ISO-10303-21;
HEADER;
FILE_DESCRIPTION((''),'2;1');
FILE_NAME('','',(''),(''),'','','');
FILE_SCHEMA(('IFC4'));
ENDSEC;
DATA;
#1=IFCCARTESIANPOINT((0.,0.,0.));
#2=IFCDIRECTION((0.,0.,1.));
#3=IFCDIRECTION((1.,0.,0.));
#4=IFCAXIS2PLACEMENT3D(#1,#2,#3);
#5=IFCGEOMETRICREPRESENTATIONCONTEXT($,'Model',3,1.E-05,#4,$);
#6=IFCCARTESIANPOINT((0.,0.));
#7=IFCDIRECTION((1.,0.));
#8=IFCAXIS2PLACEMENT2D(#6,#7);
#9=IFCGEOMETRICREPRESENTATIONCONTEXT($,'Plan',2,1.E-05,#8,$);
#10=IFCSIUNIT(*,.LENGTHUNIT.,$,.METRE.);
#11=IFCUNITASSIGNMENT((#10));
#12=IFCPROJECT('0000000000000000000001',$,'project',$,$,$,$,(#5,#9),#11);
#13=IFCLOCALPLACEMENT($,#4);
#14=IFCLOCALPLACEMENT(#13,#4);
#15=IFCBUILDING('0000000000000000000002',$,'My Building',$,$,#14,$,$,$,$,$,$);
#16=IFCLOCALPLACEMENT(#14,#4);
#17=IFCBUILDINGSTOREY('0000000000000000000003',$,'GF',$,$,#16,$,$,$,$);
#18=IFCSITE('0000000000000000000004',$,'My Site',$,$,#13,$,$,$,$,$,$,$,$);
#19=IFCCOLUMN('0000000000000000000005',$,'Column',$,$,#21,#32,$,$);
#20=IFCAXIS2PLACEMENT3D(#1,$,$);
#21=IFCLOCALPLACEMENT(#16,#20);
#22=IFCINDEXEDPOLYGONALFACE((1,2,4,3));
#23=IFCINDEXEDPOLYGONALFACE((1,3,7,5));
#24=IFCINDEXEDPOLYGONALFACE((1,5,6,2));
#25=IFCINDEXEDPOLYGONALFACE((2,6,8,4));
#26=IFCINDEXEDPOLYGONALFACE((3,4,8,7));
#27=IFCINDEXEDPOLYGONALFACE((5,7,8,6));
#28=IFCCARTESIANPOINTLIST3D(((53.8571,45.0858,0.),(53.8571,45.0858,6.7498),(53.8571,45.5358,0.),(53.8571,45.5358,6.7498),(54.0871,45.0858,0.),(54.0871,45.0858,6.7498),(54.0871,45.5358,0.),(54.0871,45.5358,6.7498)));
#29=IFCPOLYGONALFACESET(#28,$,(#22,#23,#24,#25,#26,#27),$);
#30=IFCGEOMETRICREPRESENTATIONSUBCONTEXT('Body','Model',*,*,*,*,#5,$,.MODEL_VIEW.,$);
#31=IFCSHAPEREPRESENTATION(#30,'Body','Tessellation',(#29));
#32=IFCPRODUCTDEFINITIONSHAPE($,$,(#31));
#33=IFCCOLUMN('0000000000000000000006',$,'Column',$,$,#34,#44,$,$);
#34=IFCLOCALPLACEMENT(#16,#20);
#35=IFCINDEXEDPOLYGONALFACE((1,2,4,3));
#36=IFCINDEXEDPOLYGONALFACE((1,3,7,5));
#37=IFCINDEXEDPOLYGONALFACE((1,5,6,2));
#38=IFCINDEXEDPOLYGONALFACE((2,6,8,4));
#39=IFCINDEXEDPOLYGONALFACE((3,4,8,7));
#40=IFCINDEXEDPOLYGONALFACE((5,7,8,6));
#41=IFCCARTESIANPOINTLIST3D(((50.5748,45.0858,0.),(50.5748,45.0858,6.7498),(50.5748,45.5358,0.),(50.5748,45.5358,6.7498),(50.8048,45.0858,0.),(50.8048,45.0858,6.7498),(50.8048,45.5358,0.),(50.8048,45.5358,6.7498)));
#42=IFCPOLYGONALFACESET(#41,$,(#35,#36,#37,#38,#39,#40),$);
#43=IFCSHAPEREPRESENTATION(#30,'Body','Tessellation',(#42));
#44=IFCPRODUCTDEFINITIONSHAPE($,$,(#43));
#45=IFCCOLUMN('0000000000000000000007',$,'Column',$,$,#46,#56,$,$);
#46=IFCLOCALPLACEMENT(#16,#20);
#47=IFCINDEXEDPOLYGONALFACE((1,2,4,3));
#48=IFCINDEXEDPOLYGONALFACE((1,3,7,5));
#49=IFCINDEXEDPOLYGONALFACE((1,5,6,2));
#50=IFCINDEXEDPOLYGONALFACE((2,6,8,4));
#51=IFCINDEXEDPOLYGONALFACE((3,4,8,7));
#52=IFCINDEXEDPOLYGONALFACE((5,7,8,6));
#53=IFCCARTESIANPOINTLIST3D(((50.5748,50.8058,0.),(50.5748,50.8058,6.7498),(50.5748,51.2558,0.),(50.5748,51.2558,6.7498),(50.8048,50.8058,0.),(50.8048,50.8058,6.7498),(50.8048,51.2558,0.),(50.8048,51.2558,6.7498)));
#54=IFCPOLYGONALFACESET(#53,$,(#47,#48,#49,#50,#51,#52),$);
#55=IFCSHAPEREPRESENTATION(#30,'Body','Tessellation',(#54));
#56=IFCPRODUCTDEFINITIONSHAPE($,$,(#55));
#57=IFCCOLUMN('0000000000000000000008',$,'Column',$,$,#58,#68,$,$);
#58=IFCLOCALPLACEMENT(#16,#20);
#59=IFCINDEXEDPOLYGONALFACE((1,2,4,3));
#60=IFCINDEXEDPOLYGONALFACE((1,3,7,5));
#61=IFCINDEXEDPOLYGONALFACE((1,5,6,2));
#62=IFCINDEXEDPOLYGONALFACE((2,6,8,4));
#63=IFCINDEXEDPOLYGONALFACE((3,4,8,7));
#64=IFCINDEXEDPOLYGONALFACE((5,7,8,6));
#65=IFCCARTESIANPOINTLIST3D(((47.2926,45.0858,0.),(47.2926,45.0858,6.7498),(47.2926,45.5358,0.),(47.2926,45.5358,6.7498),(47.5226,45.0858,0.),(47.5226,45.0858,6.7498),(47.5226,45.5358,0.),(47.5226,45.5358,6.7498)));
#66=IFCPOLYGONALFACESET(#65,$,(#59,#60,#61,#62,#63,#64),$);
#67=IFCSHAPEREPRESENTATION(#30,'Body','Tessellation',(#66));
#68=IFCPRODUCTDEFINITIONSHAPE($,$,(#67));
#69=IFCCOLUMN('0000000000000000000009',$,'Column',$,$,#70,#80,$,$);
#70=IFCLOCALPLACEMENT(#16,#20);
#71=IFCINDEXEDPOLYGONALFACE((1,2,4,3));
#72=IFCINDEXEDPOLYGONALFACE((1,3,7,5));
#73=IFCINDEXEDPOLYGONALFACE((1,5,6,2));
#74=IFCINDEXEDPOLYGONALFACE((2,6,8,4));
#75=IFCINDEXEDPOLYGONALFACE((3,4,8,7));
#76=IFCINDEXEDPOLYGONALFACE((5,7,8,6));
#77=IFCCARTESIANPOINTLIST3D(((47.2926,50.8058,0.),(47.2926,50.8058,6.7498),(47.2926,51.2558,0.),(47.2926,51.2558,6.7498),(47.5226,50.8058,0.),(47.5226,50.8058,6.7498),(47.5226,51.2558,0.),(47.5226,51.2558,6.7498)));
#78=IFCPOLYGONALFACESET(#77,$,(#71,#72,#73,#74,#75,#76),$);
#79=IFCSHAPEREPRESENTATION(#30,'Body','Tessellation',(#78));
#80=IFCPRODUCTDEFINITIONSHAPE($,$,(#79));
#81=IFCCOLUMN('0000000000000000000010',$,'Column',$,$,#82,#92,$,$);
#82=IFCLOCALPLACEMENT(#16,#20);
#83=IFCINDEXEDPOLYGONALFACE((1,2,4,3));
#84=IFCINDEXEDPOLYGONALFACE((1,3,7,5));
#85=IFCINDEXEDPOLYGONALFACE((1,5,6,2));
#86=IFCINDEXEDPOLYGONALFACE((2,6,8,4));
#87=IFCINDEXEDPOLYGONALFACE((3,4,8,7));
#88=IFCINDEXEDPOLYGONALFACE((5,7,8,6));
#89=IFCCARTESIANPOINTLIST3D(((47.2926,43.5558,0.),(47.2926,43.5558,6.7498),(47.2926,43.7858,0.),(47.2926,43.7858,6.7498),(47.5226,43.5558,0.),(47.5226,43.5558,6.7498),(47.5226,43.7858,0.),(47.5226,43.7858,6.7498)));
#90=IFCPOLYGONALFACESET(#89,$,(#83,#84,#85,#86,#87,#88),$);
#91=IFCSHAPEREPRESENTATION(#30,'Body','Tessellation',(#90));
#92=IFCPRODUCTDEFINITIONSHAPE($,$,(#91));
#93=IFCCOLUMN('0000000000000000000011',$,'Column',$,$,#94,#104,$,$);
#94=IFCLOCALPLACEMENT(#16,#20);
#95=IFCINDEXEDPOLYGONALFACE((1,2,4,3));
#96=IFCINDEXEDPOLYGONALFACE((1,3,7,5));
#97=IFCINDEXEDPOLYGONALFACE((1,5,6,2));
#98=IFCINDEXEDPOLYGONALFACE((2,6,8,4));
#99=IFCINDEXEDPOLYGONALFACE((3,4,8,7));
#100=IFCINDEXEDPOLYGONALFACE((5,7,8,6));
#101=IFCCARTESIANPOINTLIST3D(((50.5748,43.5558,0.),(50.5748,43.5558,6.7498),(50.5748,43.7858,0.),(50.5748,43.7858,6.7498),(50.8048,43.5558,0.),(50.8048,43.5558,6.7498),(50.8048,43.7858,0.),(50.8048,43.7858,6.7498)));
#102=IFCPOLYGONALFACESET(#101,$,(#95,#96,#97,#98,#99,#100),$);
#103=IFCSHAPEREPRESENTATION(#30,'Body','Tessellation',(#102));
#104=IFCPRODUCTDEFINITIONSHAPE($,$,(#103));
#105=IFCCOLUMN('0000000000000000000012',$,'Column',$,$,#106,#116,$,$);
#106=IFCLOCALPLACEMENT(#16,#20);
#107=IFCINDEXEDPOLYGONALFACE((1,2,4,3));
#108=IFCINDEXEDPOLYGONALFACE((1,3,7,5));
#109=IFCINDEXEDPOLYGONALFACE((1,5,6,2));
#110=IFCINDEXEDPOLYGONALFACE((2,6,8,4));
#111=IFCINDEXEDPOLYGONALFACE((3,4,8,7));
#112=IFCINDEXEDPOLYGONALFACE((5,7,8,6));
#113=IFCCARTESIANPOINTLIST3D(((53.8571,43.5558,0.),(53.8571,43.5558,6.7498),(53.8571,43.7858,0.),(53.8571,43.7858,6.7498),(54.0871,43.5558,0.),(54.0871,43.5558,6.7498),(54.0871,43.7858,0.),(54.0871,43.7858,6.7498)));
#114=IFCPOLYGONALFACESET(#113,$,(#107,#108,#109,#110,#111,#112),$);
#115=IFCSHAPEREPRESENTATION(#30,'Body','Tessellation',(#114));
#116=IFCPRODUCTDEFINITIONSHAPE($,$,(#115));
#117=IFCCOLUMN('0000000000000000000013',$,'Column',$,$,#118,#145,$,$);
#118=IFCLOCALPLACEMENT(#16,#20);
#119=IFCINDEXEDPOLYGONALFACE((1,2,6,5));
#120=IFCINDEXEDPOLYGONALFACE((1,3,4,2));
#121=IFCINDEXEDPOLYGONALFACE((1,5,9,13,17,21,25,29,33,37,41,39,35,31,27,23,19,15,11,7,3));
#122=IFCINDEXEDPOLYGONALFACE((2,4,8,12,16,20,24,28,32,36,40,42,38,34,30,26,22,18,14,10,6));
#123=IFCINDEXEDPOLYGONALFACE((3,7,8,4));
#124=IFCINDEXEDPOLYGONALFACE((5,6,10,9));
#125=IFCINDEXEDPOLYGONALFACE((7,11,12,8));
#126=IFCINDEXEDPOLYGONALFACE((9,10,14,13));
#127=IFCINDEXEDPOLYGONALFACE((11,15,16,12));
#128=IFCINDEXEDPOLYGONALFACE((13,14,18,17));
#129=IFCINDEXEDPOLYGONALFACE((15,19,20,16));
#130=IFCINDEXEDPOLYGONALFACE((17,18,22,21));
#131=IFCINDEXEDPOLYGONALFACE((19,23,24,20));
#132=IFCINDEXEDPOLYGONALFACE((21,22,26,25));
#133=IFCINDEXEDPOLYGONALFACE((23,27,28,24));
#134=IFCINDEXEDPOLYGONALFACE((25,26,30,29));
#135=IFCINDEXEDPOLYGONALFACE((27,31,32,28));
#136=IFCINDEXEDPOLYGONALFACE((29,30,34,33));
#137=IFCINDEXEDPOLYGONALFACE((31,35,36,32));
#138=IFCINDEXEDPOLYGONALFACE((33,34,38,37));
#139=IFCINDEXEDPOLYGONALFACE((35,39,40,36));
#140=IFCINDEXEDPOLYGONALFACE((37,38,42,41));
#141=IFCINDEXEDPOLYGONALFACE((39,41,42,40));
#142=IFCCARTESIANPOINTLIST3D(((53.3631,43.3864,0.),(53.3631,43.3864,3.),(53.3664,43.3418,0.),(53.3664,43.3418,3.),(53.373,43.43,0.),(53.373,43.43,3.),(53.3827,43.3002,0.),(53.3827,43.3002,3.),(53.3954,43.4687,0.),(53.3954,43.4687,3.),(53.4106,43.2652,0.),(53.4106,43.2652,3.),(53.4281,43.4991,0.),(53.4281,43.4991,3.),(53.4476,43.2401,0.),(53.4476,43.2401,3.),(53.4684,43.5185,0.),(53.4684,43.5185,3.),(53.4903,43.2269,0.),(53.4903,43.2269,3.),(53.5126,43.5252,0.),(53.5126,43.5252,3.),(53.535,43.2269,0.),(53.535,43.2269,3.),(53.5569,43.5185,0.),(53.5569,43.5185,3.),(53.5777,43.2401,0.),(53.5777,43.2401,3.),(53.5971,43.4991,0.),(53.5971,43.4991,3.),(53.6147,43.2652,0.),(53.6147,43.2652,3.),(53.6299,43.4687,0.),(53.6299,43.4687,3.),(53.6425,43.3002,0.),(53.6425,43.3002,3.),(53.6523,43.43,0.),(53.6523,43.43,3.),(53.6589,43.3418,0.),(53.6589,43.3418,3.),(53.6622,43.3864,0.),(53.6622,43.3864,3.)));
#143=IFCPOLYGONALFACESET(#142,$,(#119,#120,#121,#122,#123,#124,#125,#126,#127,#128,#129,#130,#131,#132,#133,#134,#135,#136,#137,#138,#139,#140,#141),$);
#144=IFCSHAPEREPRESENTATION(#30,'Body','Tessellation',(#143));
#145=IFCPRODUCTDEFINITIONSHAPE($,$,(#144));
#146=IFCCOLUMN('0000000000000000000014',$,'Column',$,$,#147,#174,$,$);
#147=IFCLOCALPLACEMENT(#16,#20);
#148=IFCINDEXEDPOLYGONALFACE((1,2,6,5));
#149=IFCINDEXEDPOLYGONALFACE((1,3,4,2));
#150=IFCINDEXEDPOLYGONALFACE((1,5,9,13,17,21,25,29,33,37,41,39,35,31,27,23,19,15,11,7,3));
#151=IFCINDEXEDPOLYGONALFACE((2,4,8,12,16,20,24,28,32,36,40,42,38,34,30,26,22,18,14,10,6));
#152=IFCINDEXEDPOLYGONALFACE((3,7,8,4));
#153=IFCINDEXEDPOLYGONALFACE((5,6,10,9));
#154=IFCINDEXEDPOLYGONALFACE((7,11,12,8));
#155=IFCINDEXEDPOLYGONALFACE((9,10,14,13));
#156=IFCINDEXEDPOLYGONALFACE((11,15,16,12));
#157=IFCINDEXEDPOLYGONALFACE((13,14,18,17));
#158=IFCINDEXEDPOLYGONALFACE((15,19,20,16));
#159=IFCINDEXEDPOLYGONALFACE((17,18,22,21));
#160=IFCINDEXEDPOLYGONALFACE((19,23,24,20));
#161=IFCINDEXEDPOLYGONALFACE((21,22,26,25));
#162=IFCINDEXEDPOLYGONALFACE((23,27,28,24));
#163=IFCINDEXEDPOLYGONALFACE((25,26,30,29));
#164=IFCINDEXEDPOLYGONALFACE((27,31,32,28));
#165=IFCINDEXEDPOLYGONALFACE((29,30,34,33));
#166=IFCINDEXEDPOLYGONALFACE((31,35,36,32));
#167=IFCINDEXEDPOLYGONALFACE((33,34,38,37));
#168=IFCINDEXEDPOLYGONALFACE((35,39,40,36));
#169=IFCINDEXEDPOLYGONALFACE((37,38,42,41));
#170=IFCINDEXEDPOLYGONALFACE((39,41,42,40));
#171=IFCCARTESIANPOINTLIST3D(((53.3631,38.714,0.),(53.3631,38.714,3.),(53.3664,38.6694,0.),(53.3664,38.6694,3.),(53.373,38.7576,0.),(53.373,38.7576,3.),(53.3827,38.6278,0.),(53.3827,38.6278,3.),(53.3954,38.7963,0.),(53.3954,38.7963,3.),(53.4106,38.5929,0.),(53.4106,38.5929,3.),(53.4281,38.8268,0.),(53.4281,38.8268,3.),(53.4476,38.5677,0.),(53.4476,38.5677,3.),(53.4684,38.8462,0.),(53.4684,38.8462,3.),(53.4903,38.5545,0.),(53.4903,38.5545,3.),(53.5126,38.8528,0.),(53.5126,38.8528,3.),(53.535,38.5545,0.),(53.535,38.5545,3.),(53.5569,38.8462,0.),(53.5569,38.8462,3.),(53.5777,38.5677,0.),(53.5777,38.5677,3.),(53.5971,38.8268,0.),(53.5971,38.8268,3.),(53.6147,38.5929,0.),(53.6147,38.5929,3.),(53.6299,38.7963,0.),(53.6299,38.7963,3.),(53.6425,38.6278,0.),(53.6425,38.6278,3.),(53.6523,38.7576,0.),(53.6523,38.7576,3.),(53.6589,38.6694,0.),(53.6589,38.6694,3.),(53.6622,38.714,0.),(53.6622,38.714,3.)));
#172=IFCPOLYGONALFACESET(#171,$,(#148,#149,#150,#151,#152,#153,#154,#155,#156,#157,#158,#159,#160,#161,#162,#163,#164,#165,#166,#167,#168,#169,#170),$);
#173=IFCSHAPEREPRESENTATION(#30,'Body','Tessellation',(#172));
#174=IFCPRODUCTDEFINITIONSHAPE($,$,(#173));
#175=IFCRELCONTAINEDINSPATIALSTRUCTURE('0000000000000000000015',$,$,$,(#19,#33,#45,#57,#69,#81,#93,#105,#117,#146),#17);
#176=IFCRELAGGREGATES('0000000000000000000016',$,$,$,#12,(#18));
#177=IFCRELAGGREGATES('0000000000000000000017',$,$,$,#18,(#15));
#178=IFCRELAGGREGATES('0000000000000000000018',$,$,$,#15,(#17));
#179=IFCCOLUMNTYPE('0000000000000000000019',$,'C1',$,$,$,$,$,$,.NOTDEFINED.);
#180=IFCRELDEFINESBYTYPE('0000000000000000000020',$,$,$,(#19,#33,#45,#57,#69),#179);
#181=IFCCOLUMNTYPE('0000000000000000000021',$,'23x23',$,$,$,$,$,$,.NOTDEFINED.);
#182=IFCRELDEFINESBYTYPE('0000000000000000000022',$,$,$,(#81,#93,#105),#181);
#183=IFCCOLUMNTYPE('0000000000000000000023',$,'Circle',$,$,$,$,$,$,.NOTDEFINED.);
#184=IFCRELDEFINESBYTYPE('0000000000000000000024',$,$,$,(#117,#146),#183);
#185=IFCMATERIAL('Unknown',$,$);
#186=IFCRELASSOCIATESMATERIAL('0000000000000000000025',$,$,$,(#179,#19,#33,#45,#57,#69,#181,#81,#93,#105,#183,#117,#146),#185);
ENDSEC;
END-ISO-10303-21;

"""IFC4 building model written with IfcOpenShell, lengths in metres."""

from ifc_helpers import new_model, si_unit, frame, origin_with_axes, origin_2d_with_axis, place, context, subcontext, project, spatial, rectangle, circle, extrude, material, material_profile, profile_set, profile_usage, type_object, element, save


model = new_model("IFC4")

# Units and contexts
model_context = context("Model", 3, precision=1e-05, world=origin_with_axes())
plan_context = context("Plan", 2, precision=1e-05, world=origin_2d_with_axis())
body_context = subcontext(model_context, "Body", "Model", "MODEL_VIEW")
ifc_project = project(units=[si_unit("LENGTHUNIT", "METRE")], contexts=[model_context, plan_context])

# Site, building, storey
site_placement = place(None, origin_with_axes())
site = spatial("IfcSite", under=ifc_project, at=site_placement, Name="My Site")
building_placement = place(site_placement, origin_with_axes())
building = spatial("IfcBuilding", under=site, at=building_placement, Name="My Building")
storey_placement = place(building_placement, origin_with_axes())
storey = spatial("IfcBuildingStorey", under=building, at=storey_placement, Name="GF")

# Columns
ifc_material = material(Name="Unknown")
ifc_material_profile_1 = material_profile(ifc_material, rectangle(XDim=0.45, YDim=0.23))
ifc_profile_set_1 = profile_set([ifc_material_profile_1])
ifc_profile_usage_1 = profile_usage(ifc_profile_set_1, cardinal=5)
column_type_1 = type_object("IfcColumnType", Name="C1", PredefinedType="NOTDEFINED", material=ifc_profile_set_1)
column_1_placement = place(storey_placement, frame((53.9721, 45.3108, 0.0), z_axis=(0.0, 0.0, 1.0), x_axis=(0.0, 1.0, 0.0)))
element("IfcColumn", 1, at=column_1_placement, inside=storey, type_object=column_type_1, material=ifc_profile_usage_1, Name="Column", context=body_context, shape_type="SweptSolid", body=[
    extrude(rectangle(XDim=0.45, YDim=0.23), origin_with_axes(), (0.0, 0.0, 1.0), 6.7498),
])
ifc_profile_usage_2 = profile_usage(ifc_profile_set_1, cardinal=5)
column_2_placement = place(storey_placement, frame((50.6898, 45.3108, 0.0), z_axis=(0.0, 0.0, 1.0), x_axis=(0.0, 1.0, 0.0)))
element("IfcColumn", 2, at=column_2_placement, inside=storey, type_object=column_type_1, material=ifc_profile_usage_2, Name="Column", context=body_context, shape_type="SweptSolid", body=[
    extrude(rectangle(XDim=0.45, YDim=0.23), origin_with_axes(), (0.0, 0.0, 1.0), 6.7498),
])
ifc_profile_usage_3 = profile_usage(ifc_profile_set_1, cardinal=5)
column_3_placement = place(storey_placement, frame((50.6898, 51.0308, 0.0), z_axis=(0.0, 0.0, 1.0), x_axis=(0.0, 1.0, 0.0)))
element("IfcColumn", 3, at=column_3_placement, inside=storey, type_object=column_type_1, material=ifc_profile_usage_3, Name="Column", context=body_context, shape_type="SweptSolid", body=[
    extrude(rectangle(XDim=0.45, YDim=0.23), origin_with_axes(), (0.0, 0.0, 1.0), 6.7498),
])
ifc_profile_usage_4 = profile_usage(ifc_profile_set_1, cardinal=5)
column_4_placement = place(storey_placement, frame((47.4076, 45.3108, 0.0), z_axis=(0.0, 0.0, 1.0), x_axis=(0.0, 1.0, 0.0)))
element("IfcColumn", 4, at=column_4_placement, inside=storey, type_object=column_type_1, material=ifc_profile_usage_4, Name="Column", context=body_context, shape_type="SweptSolid", body=[
    extrude(rectangle(XDim=0.45, YDim=0.23), origin_with_axes(), (0.0, 0.0, 1.0), 6.7498),
])
ifc_profile_usage_5 = profile_usage(ifc_profile_set_1, cardinal=5)
column_5_placement = place(storey_placement, frame((47.4076, 51.0308, 0.0), z_axis=(0.0, 0.0, 1.0), x_axis=(0.0, 1.0, 0.0)))
element("IfcColumn", 5, at=column_5_placement, inside=storey, type_object=column_type_1, material=ifc_profile_usage_5, Name="Column", context=body_context, shape_type="SweptSolid", body=[
    extrude(rectangle(XDim=0.45, YDim=0.23), origin_with_axes(), (0.0, 0.0, 1.0), 6.7498),
])
ifc_material_profile_2 = material_profile(ifc_material, rectangle(XDim=0.23, YDim=0.23))
ifc_profile_set_2 = profile_set([ifc_material_profile_2])
ifc_profile_usage_6 = profile_usage(ifc_profile_set_2, cardinal=5)
column_type_2 = type_object("IfcColumnType", Name="23x23", PredefinedType="NOTDEFINED", material=ifc_profile_set_2)
column_6_placement = place(storey_placement, frame((47.4076, 43.6708, 0.0), z_axis=(0.0, 0.0, 1.0), x_axis=(1.0, 0.0, 0.0)))
element("IfcColumn", 6, at=column_6_placement, inside=storey, type_object=column_type_2, material=ifc_profile_usage_6, Name="Column", context=body_context, shape_type="SweptSolid", body=[
    extrude(rectangle(XDim=0.23, YDim=0.23), origin_with_axes(), (0.0, 0.0, 1.0), 6.7498),
])
ifc_profile_usage_7 = profile_usage(ifc_profile_set_2, cardinal=5)
column_7_placement = place(storey_placement, frame((50.6898, 43.6708, 0.0), z_axis=(0.0, 0.0, 1.0), x_axis=(1.0, 0.0, 0.0)))
element("IfcColumn", 7, at=column_7_placement, inside=storey, type_object=column_type_2, material=ifc_profile_usage_7, Name="Column", context=body_context, shape_type="SweptSolid", body=[
    extrude(rectangle(XDim=0.23, YDim=0.23), origin_with_axes(), (0.0, 0.0, 1.0), 6.7498),
])
ifc_profile_usage_8 = profile_usage(ifc_profile_set_2, cardinal=5)
column_8_placement = place(storey_placement, frame((53.9721, 43.6708, 0.0), z_axis=(0.0, 0.0, 1.0), x_axis=(1.0, 0.0, 0.0)))
element("IfcColumn", 8, at=column_8_placement, inside=storey, type_object=column_type_2, material=ifc_profile_usage_8, Name="Column", context=body_context, shape_type="SweptSolid", body=[
    extrude(rectangle(XDim=0.23, YDim=0.23), origin_with_axes(), (0.0, 0.0, 1.0), 6.7498),
])
ifc_material_profile_3 = material_profile(ifc_material, circle(Radius=0.15))
ifc_profile_set_3 = profile_set([ifc_material_profile_3])
ifc_profile_usage_9 = profile_usage(ifc_profile_set_3, cardinal=5)
column_type_3 = type_object("IfcColumnType", Name="Circle", PredefinedType="NOTDEFINED", material=ifc_profile_set_3)
column_9_placement = place(storey_placement, frame((53.5126, 43.3752, 0.0), z_axis=(0.0, 0.0, 1.0), x_axis=(0.0, 1.0, 0.0)))
element("IfcColumn", 9, at=column_9_placement, inside=storey, type_object=column_type_3, material=ifc_profile_usage_9, Name="Column", context=body_context, shape_type="SweptSolid", body=[
    extrude(circle(Radius=0.15), origin_with_axes(), (0.0, 0.0, 1.0), 3.0),
])
ifc_profile_usage_10 = profile_usage(ifc_profile_set_3, cardinal=5)
column_10_placement = place(storey_placement, frame((53.5126, 38.7028, 0.0), z_axis=(0.0, 0.0, 1.0), x_axis=(0.0, 1.0, 0.0)))
element("IfcColumn", 10, at=column_10_placement, inside=storey, type_object=column_type_3, material=ifc_profile_usage_10, Name="Column", context=body_context, shape_type="SweptSolid", body=[
    extrude(circle(Radius=0.15), origin_with_axes(), (0.0, 0.0, 1.0), 3.0),
])

save(model, "model.ifc")
